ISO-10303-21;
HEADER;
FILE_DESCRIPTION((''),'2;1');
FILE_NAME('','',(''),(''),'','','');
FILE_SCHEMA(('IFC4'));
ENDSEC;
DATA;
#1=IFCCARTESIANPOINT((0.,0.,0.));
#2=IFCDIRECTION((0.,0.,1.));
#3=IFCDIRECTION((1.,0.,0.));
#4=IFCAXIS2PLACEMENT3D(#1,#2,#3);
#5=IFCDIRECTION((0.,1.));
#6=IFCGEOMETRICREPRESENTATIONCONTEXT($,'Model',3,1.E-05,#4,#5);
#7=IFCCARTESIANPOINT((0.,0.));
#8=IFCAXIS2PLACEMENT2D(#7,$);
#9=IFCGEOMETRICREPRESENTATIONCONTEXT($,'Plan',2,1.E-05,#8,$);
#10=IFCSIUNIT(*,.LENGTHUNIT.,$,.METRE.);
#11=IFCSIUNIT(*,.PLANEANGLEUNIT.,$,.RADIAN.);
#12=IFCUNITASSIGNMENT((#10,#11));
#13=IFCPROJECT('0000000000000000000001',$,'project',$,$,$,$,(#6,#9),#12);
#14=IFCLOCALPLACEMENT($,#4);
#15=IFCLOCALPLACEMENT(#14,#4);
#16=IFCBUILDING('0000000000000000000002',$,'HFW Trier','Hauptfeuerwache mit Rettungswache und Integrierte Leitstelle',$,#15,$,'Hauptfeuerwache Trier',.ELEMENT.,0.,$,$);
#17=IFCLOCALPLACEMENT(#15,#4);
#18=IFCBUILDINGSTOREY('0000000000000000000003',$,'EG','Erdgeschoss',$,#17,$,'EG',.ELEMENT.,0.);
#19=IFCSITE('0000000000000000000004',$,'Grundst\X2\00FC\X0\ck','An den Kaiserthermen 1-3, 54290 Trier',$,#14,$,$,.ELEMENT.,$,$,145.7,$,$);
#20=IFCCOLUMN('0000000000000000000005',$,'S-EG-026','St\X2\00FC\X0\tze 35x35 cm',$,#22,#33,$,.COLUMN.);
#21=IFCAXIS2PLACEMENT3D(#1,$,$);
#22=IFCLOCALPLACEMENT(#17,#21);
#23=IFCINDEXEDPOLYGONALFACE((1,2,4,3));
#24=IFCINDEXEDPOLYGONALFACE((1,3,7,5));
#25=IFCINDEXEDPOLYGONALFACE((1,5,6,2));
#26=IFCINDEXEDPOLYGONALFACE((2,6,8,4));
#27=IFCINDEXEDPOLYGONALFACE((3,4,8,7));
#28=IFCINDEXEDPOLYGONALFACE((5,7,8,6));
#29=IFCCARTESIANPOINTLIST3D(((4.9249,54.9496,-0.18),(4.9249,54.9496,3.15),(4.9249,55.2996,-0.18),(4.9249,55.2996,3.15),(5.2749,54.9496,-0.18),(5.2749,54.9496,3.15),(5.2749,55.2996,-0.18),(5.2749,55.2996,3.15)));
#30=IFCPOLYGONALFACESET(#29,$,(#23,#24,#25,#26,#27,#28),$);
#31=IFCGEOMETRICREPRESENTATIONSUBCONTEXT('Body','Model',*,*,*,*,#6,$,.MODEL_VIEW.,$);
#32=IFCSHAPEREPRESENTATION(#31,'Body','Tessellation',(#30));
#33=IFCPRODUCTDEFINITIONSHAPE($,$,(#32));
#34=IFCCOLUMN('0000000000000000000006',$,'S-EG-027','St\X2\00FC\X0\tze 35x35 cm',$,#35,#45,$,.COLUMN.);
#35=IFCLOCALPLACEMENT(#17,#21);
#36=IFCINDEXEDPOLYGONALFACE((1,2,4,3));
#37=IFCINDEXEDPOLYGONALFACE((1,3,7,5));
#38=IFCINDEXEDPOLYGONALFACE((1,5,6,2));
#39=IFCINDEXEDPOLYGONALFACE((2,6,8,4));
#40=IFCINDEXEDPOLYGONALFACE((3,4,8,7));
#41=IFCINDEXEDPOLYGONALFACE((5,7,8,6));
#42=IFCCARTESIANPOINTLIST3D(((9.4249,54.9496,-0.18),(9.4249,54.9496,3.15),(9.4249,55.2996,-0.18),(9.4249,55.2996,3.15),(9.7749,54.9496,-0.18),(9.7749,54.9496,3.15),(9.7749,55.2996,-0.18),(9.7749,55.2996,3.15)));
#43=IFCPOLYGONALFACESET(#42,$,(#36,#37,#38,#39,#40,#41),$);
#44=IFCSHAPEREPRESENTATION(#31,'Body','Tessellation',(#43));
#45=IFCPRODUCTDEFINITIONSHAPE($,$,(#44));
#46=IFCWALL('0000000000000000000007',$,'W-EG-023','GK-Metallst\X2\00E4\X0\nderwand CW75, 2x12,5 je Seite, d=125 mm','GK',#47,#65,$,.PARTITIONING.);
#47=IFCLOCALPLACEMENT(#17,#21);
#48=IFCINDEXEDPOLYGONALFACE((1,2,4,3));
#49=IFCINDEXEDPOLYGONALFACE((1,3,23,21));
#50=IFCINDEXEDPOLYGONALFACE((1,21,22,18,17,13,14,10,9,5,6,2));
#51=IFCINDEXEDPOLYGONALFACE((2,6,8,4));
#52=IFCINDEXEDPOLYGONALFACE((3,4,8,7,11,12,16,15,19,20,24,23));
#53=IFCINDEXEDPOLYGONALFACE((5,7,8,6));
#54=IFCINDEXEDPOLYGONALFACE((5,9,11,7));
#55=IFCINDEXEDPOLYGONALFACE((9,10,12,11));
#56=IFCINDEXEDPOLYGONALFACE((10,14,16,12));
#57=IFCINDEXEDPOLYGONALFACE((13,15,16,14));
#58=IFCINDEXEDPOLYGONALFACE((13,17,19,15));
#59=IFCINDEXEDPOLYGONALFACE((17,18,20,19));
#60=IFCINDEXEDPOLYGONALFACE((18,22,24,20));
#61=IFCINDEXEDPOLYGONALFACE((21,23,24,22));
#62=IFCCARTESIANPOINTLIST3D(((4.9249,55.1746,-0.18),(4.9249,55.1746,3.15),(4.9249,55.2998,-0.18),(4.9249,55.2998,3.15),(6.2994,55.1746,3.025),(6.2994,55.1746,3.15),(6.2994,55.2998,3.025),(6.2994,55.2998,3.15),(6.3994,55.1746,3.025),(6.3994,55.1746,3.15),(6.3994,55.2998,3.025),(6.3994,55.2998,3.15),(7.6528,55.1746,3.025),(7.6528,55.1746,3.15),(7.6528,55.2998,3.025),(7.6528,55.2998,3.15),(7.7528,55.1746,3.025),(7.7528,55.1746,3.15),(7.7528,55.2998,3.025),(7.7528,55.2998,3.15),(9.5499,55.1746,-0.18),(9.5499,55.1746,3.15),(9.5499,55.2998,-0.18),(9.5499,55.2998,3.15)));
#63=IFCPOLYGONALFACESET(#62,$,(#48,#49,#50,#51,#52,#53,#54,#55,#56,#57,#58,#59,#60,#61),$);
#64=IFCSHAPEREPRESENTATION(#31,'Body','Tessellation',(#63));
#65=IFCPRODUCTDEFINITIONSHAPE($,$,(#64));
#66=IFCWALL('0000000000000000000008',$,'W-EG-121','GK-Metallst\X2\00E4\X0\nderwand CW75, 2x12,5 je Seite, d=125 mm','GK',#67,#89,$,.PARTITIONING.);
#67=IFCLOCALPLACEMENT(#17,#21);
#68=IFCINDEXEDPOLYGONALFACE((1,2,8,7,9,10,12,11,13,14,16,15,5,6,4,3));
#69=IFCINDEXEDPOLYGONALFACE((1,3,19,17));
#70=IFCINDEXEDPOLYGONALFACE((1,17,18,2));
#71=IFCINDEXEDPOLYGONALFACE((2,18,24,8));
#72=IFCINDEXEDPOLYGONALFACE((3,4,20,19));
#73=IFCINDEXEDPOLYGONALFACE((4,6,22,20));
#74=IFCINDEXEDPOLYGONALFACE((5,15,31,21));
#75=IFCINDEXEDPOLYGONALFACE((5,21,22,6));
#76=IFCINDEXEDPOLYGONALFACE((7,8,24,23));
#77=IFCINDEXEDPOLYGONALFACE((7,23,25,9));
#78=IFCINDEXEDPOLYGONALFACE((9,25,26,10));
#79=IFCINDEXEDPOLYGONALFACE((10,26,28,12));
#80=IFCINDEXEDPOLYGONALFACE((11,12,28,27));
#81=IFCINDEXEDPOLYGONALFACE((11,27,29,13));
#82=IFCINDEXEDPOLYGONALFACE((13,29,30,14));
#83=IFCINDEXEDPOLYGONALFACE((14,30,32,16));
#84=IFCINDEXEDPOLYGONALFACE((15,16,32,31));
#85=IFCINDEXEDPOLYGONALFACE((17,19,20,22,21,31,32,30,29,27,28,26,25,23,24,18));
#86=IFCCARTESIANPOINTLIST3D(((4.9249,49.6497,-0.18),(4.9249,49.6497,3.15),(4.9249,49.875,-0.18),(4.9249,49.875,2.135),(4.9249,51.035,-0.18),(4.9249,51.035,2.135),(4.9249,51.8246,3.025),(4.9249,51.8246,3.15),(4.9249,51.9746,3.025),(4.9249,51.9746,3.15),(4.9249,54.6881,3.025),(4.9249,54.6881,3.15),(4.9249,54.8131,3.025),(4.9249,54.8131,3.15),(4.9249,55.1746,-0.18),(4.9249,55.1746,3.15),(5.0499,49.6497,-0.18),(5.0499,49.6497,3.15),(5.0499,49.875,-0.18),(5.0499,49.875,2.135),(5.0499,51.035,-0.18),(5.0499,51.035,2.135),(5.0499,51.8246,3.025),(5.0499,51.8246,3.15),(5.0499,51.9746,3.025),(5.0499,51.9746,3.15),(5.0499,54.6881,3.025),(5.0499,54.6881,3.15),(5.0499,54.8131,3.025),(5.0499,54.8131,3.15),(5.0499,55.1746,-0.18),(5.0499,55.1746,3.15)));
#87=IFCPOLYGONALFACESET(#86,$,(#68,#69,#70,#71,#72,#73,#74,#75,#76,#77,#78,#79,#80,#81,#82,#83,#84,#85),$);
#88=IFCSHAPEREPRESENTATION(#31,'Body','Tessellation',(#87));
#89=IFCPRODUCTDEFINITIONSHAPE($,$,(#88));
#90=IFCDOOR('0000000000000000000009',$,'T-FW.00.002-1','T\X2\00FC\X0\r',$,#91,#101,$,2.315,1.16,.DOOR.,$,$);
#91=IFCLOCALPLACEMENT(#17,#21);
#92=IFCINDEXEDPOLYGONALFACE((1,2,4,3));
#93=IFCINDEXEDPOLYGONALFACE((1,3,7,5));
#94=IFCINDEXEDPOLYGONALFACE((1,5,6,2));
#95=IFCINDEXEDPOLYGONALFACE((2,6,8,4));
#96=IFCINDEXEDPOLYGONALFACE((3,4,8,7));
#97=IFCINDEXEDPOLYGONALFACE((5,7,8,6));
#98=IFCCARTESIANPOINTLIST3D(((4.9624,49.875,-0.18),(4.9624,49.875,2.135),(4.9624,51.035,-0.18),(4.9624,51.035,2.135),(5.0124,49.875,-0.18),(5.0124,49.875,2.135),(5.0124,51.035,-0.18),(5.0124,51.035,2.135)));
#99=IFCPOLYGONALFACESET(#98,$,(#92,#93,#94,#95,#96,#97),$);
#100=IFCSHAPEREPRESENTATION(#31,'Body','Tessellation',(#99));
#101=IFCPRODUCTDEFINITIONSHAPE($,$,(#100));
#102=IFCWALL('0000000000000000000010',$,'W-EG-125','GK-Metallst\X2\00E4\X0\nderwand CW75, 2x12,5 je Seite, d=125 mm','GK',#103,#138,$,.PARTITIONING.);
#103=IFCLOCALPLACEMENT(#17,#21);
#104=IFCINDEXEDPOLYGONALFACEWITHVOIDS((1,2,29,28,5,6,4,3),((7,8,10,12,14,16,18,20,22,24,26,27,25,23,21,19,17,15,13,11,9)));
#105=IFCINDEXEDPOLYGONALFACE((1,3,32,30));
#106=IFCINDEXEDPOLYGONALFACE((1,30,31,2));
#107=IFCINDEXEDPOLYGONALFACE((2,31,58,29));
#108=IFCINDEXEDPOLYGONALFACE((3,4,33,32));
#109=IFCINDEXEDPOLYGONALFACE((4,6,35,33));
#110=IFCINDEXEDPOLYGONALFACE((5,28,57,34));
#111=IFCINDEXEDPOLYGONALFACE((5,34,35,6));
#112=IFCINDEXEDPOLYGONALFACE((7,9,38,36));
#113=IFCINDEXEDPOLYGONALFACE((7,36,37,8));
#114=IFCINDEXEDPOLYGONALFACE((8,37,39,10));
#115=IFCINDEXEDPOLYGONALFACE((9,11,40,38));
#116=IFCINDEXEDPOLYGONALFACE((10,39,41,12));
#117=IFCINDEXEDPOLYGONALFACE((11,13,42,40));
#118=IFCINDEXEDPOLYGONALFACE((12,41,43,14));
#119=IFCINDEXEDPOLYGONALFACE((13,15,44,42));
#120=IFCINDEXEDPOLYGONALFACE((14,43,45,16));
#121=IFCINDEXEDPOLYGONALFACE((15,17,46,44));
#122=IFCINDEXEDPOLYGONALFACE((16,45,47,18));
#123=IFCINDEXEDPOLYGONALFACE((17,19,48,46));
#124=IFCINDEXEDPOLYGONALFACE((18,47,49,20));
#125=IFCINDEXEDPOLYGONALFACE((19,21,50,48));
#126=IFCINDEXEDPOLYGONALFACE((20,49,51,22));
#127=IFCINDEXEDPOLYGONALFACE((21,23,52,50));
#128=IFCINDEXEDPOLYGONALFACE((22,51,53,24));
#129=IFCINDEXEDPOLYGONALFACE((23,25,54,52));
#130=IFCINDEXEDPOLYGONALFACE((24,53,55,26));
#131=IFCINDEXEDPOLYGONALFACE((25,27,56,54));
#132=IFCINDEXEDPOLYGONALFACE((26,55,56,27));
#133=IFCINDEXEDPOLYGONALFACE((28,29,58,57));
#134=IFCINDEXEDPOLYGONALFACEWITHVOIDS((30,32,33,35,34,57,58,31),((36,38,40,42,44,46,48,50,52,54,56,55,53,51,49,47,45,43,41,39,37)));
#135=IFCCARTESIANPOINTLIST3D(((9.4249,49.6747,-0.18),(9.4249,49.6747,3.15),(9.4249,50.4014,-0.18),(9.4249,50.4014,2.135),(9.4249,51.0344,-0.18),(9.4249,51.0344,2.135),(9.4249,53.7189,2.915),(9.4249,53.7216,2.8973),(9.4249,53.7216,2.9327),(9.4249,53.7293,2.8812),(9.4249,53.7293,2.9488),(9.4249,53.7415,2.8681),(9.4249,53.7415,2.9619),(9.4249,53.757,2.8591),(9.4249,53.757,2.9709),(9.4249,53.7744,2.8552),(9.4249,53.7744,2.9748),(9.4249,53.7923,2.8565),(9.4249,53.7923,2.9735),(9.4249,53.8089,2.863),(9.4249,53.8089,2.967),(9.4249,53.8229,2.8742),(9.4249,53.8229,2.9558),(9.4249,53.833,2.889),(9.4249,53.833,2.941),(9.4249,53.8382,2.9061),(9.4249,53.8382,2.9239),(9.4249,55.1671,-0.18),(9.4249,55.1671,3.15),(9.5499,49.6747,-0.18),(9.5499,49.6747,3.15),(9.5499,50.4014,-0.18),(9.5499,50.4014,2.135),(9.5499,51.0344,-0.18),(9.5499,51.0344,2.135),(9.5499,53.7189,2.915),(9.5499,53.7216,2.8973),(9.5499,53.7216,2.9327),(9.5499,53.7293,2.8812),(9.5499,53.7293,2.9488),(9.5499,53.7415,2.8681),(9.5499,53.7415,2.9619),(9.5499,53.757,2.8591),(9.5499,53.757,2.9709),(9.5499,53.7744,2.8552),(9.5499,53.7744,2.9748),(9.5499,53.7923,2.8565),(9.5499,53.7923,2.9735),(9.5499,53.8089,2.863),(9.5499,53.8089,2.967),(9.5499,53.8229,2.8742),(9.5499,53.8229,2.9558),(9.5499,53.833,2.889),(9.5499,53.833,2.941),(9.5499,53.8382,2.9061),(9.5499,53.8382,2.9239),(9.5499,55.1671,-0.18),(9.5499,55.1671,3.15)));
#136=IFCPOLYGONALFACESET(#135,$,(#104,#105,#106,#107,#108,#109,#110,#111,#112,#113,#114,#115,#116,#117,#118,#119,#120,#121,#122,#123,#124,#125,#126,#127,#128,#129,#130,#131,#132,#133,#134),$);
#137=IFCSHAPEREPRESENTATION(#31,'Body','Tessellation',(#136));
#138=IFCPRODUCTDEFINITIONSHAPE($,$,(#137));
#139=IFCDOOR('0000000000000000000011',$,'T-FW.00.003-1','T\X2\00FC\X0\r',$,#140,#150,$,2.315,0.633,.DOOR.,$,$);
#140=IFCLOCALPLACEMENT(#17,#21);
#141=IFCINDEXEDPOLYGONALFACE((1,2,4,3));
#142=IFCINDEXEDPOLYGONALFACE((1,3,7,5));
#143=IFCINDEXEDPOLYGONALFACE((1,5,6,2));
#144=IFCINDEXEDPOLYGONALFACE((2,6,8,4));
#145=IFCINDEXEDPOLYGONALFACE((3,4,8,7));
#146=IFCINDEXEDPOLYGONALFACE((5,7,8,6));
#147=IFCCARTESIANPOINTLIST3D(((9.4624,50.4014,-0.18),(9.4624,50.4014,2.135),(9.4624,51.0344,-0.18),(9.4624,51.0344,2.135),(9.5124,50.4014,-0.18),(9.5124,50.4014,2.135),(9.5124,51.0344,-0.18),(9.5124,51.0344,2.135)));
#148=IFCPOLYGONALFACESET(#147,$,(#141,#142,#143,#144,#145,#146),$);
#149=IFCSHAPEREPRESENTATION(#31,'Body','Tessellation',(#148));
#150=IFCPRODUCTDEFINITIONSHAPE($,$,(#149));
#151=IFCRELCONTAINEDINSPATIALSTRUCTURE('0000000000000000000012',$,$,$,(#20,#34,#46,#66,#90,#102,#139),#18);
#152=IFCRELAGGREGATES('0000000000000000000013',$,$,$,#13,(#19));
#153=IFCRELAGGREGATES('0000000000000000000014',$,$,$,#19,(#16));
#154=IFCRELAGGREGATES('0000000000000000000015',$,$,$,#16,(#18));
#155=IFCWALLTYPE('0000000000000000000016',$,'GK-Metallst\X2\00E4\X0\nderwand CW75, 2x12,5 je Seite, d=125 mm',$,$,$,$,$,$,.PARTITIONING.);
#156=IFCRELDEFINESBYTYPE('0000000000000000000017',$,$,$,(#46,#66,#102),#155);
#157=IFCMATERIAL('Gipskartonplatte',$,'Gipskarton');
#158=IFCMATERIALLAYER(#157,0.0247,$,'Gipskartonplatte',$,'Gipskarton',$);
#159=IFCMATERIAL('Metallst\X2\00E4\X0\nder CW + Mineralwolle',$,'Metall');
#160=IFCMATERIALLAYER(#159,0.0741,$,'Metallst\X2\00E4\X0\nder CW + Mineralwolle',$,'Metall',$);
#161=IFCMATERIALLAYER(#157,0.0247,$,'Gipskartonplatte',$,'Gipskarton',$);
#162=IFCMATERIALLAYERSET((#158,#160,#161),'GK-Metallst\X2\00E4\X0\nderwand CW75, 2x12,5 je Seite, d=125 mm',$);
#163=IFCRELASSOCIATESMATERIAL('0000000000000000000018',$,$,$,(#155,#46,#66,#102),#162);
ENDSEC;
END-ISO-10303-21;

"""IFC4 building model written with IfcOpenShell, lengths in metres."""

from ifc_helpers import new_model, si_unit, direction, frame, frame_2d, origin_with_axes, origin_2d, place, context, subcontext, project, spatial, rectangle, circle, extrude, material, layer, layer_set, layer_usage, type_object, element, fill, save


model = new_model("IFC4")

# Units and contexts
model_context = context("Model", 3, precision=1e-05, world=origin_with_axes(), true_north=direction((0.0, 1.0)))
plan_context = context("Plan", 2, precision=1e-05, world=origin_2d())
body_context = subcontext(model_context, "Body", "Model", "MODEL_VIEW")
ifc_project = project(units=[si_unit("LENGTHUNIT", "METRE"), si_unit("PLANEANGLEUNIT", "RADIAN")], contexts=[model_context, plan_context])

# Site, building, storey
site_placement = place(None, origin_with_axes())
site = spatial("IfcSite", under=ifc_project, at=site_placement, Name="Grundstück", Description="An den Kaiserthermen 1-3, 54290 Trier", CompositionType="ELEMENT", RefElevation=145.7)
building_placement = place(site_placement, origin_with_axes())
building = spatial("IfcBuilding", under=site, at=building_placement, Name="HFW Trier", Description="Hauptfeuerwache mit Rettungswache und Integrierte Leitstelle", LongName="Hauptfeuerwache Trier", CompositionType="ELEMENT", ElevationOfRefHeight=0.0)
storey_placement = place(building_placement, origin_with_axes())
storey = spatial("IfcBuildingStorey", under=building, at=storey_placement, Name="EG", Description="Erdgeschoss", LongName="EG", CompositionType="ELEMENT", Elevation=0.0)

# Columns
for number, where, z_axis, x_axis, name in (
    (1, (4.9249, 55.1246, -0.18), (0.0, 0.0, 1.0), (1.0, 0.0, 0.0), "S-EG-026"),
    (2, (9.4249, 55.1246, -0.18), (0.0, 0.0, 1.0), (1.0, 0.0, 0.0), "S-EG-027"),
):
    element("IfcColumn", number, at=place(storey_placement, frame(where, z_axis=z_axis, x_axis=x_axis)), inside=storey, Name=name, Description="Stütze 35x35 cm", PredefinedType="COLUMN", context=body_context, shape_type="SweptSolid", body=[
        extrude(rectangle(XDim=0.35, YDim=0.35, at=frame_2d((0.175, 0.0))), origin_with_axes(), (0.0, 0.0, 1.0), 3.33),
    ])

# Wall, openings
ifc_material_1 = material(Name="Gipskartonplatte", Category="Gipskarton")
ifc_layer_1 = layer(ifc_material_1, 0.0247, Name="Gipskartonplatte", Category="Gipskarton")
ifc_material_2 = material(Name="Metallständer CW + Mineralwolle", Category="Metall")
ifc_layer_2 = layer(ifc_material_2, 0.0741, Name="Metallständer CW + Mineralwolle", Category="Metall")
ifc_layer_3 = layer(ifc_material_1, 0.0247, Name="Gipskartonplatte", Category="Gipskarton")
ifc_layer_set_1 = layer_set([ifc_layer_1, ifc_layer_2, ifc_layer_3], Name="GK-Metallständerwand CW75, 2x12,5 je Seite, d=125 mm")
ifc_layer_usage_1 = layer_usage(ifc_layer_set_1, "AXIS2", "POSITIVE", -0.0625)
wall_type_1 = type_object("IfcWallType", Name="GK-Metallständerwand CW75, 2x12,5 je Seite, d=125 mm", PredefinedType="PARTITIONING", material=ifc_layer_set_1)
wall_1_placement = place(storey_placement, frame((4.9249, 55.2372, -0.18), z_axis=(0.0, 0.0, 1.0), x_axis=(1.0, 0.0, 0.0)))
wall_1 = element("IfcWall", 3, at=wall_1_placement, inside=storey, type_object=wall_type_1, material=ifc_layer_usage_1, Name="W-EG-023", Description="GK-Metallständerwand CW75, 2x12,5 je Seite, d=125 mm", ObjectType="GK", PredefinedType="PARTITIONING", context=body_context, shape_type="SweptSolid", body=[
    extrude(rectangle(XDim=4.625, YDim=0.1251, at=frame_2d((2.3125, 0.0))), origin_with_axes(), (0.0, 0.0, 1.0), 3.33),
])
opening_1_placement = place(wall_1_placement, origin_with_axes())
element("IfcOpeningElement", 4, at=opening_1_placement, cuts=wall_1, ObjectType="Wanddurchbruch", PredefinedType="OPENING", context=body_context, shape_type="SweptSolid", body=[
    extrude(rectangle(XDim=0.1, YDim=0.2251, at=frame_2d((1.4245, 0.0))), frame((0.0, 0.0, 3.205), z_axis=(0.0, 0.0, 1.0), x_axis=(1.0, 0.0, 0.0)), (0.0, 0.0, 1.0), 0.125),
])
opening_2_placement = place(wall_1_placement, origin_with_axes())
element("IfcOpeningElement", 5, at=opening_2_placement, cuts=wall_1, ObjectType="Wanddurchbruch", PredefinedType="OPENING", context=body_context, shape_type="SweptSolid", body=[
    extrude(rectangle(XDim=0.1, YDim=0.2251, at=frame_2d((2.7779, 0.0))), frame((0.0, 0.0, 3.205), z_axis=(0.0, 0.0, 1.0), x_axis=(1.0, 0.0, 0.0)), (0.0, 0.0, 1.0), 0.125),
])

# Walls, openings, doors
ifc_layer_usage_2 = layer_usage(ifc_layer_set_1, "AXIS2", "POSITIVE", -0.0625)
wall_2_placement = place(storey_placement, frame((4.9874, 55.1746, -0.18), z_axis=(0.0, 0.0, 1.0), x_axis=(0.0, -1.0, 0.0)))
wall_2 = element("IfcWall", 6, at=wall_2_placement, inside=storey, type_object=wall_type_1, material=ifc_layer_usage_2, Name="W-EG-121", Description="GK-Metallständerwand CW75, 2x12,5 je Seite, d=125 mm", ObjectType="GK", PredefinedType="PARTITIONING", context=body_context, shape_type="SweptSolid", body=[
    extrude(rectangle(XDim=5.5249, YDim=0.125, at=frame_2d((2.7624, 0.0))), origin_with_axes(), (0.0, 0.0, 1.0), 3.33),
])
opening_3_placement = place(wall_2_placement, frame((4.1396, 0.0, 0.0), z_axis=(0.0, 0.0, 1.0), x_axis=(1.0, 0.0, 0.0)))
opening_3 = element("IfcOpeningElement", 7, at=opening_3_placement, cuts=wall_2, PredefinedType="OPENING", context=body_context, shape_type="SweptSolid", body=[
    extrude(rectangle(XDim=1.16, YDim=0.225, at=frame_2d((0.58, 0.0))), origin_with_axes(), (0.0, 0.0, 1.0), 2.315),
])
opening_4_placement = place(wall_2_placement, origin_with_axes())
element("IfcOpeningElement", 8, at=opening_4_placement, cuts=wall_2, ObjectType="Wanddurchbruch", PredefinedType="OPENING", context=body_context, shape_type="SweptSolid", body=[
    extrude(rectangle(XDim=0.125, YDim=0.225, at=frame_2d((0.424, 0.0))), frame((0.0, 0.0, 3.205), z_axis=(0.0, 0.0, 1.0), x_axis=(1.0, 0.0, 0.0)), (0.0, 0.0, 1.0), 0.125),
])
opening_5_placement = place(wall_2_placement, origin_with_axes())
element("IfcOpeningElement", 9, at=opening_5_placement, cuts=wall_2, ObjectType="Wanddurchbruch", PredefinedType="OPENING", context=body_context, shape_type="SweptSolid", body=[
    extrude(rectangle(XDim=0.15, YDim=0.225, at=frame_2d((3.275, 0.0))), frame((0.0, 0.0, 3.205), z_axis=(0.0, 0.0, 1.0), x_axis=(1.0, 0.0, 0.0)), (0.0, 0.0, 1.0), 0.125),
])
door_1_placement = place(wall_2_placement, frame((4.1396, 0.0, 0.0), z_axis=(0.0, 0.0, 1.0), x_axis=(1.0, 0.0, 0.0)))
door_1 = element("IfcDoor", 10, at=door_1_placement, inside=storey, Name="T-FW.00.002-1", Description="Tür", OverallHeight=2.315, OverallWidth=1.16, PredefinedType="DOOR", context=body_context, shape_type="SweptSolid", body=[
    extrude(rectangle(XDim=1.16, YDim=0.05, at=frame_2d((0.58, 0.0))), origin_with_axes(), (0.0, 0.0, 1.0), 2.315),
])
fill(opening_3, door_1)
ifc_layer_usage_3 = layer_usage(ifc_layer_set_1, "AXIS2", "POSITIVE", -0.0625)
wall_3_placement = place(storey_placement, frame((9.4874, 55.1671, -0.18), z_axis=(0.0, 0.0, 1.0), x_axis=(0.0, -1.0, 0.0)))
wall_3 = element("IfcWall", 11, at=wall_3_placement, inside=storey, type_object=wall_type_1, material=ifc_layer_usage_3, Name="W-EG-125", Description="GK-Metallständerwand CW75, 2x12,5 je Seite, d=125 mm", ObjectType="GK", PredefinedType="PARTITIONING", context=body_context, shape_type="SweptSolid", body=[
    extrude(rectangle(XDim=5.4924, YDim=0.125, at=frame_2d((2.7462, 0.0))), origin_with_axes(), (0.0, 0.0, 1.0), 3.33),
])
opening_6_placement = place(wall_3_placement, frame((4.1327, 0.0, 0.0), z_axis=(0.0, 0.0, 1.0), x_axis=(1.0, 0.0, 0.0)))
opening_6 = element("IfcOpeningElement", 12, at=opening_6_placement, cuts=wall_3, PredefinedType="OPENING", context=body_context, shape_type="SweptSolid", body=[
    extrude(rectangle(XDim=0.633, YDim=0.225, at=frame_2d((0.3165, 0.0))), origin_with_axes(), (0.0, 0.0, 1.0), 2.315),
])
opening_7_placement = place(wall_3_placement, origin_with_axes())
element("IfcOpeningElement", 13, at=opening_7_placement, cuts=wall_3, ObjectType="Wanddurchbruch", PredefinedType="OPENING", context=body_context, shape_type="SweptSolid", body=[
    extrude(circle(Radius=0.06, at=origin_2d()), frame((1.3882, -0.1125, 3.095), z_axis=(0.0, 1.0, 0.0), x_axis=(1.0, 0.0, 0.0)), (0.0, 0.0, 1.0), 0.225),
])
door_2_placement = place(wall_3_placement, frame((4.1327, 0.0, 0.0), z_axis=(0.0, 0.0, 1.0), x_axis=(1.0, 0.0, 0.0)))
door_2 = element("IfcDoor", 14, at=door_2_placement, inside=storey, Name="T-FW.00.003-1", Description="Tür", OverallHeight=2.315, OverallWidth=0.633, PredefinedType="DOOR", context=body_context, shape_type="SweptSolid", body=[
    extrude(rectangle(XDim=0.633, YDim=0.05, at=frame_2d((0.3165, 0.0))), origin_with_axes(), (0.0, 0.0, 1.0), 2.315),
])
fill(opening_6, door_2)

save(model, "model.ifc")
